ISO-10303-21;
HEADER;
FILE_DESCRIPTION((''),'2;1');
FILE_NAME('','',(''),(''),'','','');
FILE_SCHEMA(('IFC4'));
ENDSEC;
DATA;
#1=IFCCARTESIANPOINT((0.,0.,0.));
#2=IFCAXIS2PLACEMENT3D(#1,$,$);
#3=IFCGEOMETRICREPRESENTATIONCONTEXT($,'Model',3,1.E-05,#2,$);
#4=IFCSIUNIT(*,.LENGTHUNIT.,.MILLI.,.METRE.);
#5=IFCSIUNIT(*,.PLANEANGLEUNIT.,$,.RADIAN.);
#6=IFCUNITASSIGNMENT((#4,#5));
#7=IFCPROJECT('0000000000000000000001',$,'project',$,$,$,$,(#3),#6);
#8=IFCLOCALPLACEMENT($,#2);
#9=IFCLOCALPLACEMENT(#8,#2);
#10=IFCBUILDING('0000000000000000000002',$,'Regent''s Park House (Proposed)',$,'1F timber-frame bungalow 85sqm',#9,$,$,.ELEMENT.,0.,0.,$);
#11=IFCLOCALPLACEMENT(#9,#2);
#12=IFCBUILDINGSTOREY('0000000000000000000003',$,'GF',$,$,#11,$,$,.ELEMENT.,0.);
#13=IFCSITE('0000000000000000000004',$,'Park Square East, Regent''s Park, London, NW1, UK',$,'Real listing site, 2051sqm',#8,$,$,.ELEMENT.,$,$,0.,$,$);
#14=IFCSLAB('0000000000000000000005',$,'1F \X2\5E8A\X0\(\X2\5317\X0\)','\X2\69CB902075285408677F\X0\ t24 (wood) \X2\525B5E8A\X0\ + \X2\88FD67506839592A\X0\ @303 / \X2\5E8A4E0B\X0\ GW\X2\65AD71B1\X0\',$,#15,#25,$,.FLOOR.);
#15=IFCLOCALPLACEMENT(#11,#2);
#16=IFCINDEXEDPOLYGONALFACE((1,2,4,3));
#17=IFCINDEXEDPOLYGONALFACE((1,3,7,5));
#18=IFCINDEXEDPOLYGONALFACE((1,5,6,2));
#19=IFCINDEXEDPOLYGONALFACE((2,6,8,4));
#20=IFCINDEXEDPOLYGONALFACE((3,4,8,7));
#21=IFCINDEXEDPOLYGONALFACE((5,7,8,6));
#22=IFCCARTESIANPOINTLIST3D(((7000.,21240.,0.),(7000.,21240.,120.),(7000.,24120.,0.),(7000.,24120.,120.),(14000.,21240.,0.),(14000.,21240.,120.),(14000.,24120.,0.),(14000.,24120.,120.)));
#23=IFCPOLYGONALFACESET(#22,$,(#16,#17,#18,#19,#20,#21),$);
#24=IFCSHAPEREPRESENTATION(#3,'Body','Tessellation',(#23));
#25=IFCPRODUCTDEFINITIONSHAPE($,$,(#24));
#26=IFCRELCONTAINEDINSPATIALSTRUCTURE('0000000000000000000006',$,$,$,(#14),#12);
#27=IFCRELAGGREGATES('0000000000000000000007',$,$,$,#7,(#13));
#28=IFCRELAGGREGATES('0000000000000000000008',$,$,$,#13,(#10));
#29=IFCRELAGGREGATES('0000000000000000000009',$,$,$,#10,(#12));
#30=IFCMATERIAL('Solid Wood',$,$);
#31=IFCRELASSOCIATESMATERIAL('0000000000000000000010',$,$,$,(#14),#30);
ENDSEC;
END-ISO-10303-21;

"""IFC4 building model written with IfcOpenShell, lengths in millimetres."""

from ifc_helpers import new_model, si_unit, frame, frame_2d, origin, place, context, project, spatial, rectangle, extrude, material, element, save


model = new_model("IFC4")

# Units and contexts
model_context = context("Model", 3, precision=1e-05, world=origin())
ifc_project = project(units=[si_unit("LENGTHUNIT", "METRE", prefix="MILLI"), si_unit("PLANEANGLEUNIT", "RADIAN")], contexts=[model_context])

# Site, building, storey
site_placement = place(None, origin())
site = spatial("IfcSite", under=ifc_project, at=site_placement, Name="Park Square East, Regent's Park, London, NW1, UK", ObjectType="Real listing site, 2051sqm", CompositionType="ELEMENT", RefElevation=0.0)
building_placement = place(site_placement, origin())
building = spatial("IfcBuilding", under=site, at=building_placement, Name="Regent's Park House (Proposed)", ObjectType="1F timber-frame bungalow 85sqm", CompositionType="ELEMENT", ElevationOfRefHeight=0.0, ElevationOfTerrain=0.0)
storey_placement = place(building_placement, origin())
storey = spatial("IfcBuildingStorey", under=building, at=storey_placement, Name="GF", CompositionType="ELEMENT", Elevation=0.0)

# Slab
ifc_material_1 = material(Name="Solid Wood")
slab_1_placement = place(storey_placement, frame((3500.0, 10620.0, 0.0)))
element("IfcSlab", 1, at=slab_1_placement, inside=storey, material=ifc_material_1, Name="1F 床(北)", Description="構造用合板 t24 (wood) 剛床 + 製材根太 @303 / 床下 GW断熱", PredefinedType="FLOOR", context=model_context, shape_type="SweptSolid", body=[
    extrude(rectangle(XDim=7000.0, YDim=2880.0, at=frame_2d((3500.0, 1440.0))), frame((3500.0, 10620.0, 0.0)), (0.0, 0.0, 1.0), 120.0),
])

save(model, "model.ifc")
